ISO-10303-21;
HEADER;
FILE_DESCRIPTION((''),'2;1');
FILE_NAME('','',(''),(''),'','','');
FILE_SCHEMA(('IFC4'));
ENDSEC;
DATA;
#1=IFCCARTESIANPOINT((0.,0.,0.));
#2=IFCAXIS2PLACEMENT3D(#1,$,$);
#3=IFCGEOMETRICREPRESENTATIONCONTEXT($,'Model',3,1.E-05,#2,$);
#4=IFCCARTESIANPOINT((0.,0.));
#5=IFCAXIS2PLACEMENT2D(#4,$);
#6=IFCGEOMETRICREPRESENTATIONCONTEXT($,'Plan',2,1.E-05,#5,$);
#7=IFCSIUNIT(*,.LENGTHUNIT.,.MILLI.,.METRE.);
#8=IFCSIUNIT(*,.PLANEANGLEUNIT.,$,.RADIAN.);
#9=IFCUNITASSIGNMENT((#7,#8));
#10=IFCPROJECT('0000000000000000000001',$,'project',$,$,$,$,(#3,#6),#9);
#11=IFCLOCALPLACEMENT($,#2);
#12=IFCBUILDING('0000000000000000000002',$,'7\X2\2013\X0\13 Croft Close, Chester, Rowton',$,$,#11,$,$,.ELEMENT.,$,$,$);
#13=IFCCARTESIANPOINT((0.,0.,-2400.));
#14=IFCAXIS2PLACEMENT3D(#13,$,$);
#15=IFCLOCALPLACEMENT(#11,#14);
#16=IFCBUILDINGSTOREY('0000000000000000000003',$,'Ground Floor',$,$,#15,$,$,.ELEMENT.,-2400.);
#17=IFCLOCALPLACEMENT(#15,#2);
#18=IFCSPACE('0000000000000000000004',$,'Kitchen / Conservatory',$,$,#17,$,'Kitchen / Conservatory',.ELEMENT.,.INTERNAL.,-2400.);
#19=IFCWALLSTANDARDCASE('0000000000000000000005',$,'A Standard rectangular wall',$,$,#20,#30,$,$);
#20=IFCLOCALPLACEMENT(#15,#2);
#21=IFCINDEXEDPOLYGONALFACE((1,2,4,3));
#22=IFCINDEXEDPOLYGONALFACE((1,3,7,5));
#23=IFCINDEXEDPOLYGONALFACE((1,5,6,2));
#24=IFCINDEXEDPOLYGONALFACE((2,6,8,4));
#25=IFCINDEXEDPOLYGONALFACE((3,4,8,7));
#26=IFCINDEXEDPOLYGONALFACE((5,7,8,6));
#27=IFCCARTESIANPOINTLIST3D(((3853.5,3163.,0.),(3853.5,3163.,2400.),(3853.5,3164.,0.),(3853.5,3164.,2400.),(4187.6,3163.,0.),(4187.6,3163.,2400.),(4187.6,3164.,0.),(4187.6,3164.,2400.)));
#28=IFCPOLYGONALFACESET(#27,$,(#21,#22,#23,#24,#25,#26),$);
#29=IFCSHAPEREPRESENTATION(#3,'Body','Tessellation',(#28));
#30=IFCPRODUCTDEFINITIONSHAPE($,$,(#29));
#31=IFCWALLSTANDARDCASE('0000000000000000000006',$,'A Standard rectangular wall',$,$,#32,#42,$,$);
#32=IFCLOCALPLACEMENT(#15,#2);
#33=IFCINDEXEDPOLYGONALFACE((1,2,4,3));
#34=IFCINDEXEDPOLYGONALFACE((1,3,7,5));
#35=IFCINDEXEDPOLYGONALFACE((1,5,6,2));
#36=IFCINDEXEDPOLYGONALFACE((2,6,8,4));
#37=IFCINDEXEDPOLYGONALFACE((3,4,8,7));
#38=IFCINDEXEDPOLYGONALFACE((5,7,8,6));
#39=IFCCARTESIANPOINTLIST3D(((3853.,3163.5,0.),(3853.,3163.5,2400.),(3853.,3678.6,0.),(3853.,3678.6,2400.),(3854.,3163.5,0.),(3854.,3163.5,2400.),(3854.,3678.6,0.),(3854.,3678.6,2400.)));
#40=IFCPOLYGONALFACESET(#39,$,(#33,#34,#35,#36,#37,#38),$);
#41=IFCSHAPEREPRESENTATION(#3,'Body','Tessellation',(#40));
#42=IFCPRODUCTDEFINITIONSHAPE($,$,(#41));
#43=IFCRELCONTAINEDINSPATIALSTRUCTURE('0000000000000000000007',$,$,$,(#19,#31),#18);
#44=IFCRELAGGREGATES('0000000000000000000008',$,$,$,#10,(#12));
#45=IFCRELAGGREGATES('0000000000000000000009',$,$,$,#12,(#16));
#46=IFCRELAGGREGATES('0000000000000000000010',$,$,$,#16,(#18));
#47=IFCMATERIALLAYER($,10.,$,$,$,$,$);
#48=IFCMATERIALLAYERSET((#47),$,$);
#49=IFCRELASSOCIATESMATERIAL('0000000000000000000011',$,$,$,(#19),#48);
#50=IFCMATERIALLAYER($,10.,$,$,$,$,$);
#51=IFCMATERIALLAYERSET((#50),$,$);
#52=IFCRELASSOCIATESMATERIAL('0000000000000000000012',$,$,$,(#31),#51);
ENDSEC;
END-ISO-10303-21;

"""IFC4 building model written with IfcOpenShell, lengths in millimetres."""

from ifc_helpers import new_model, si_unit, frame, origin, origin_2d, place, context, project, spatial, rectangle, extrude, layer, layer_set, layer_usage, element, save


model = new_model("IFC4")

# Units and contexts
model_context = context("Model", 3, precision=1e-05, world=origin())
plan_context = context("Plan", 2, precision=1e-05, world=origin_2d())
ifc_project = project(units=[si_unit("LENGTHUNIT", "METRE", prefix="MILLI"), si_unit("PLANEANGLEUNIT", "RADIAN")], contexts=[model_context, plan_context])

# Building, storey, space
building_placement = place(None, origin())
building = spatial("IfcBuilding", under=ifc_project, at=building_placement, Name="7–13 Croft Close, Chester, Rowton", CompositionType="ELEMENT")
storey_placement = place(building_placement, frame((0.0, 0.0, -2400.0)))
storey = spatial("IfcBuildingStorey", under=building, at=storey_placement, Name="Ground Floor", CompositionType="ELEMENT", Elevation=-2400.0)
space_1_placement = place(storey_placement, origin())
space_1 = spatial("IfcSpace", under=storey, at=space_1_placement, Name="Kitchen / Conservatory", LongName="Kitchen / Conservatory", CompositionType="ELEMENT", PredefinedType="INTERNAL", ElevationWithFlooring=-2400.0)

# Walls
ifc_layer_1 = layer(None, 10.0)
ifc_layer_set_1 = layer_set([ifc_layer_1])
ifc_layer_usage_1 = layer_usage(ifc_layer_set_1, "AXIS2", "NEGATIVE", 150.0)
wall_1_placement = place(storey_placement, origin())
element("IfcWallStandardCase", 1, at=wall_1_placement, inside=space_1, material=ifc_layer_usage_1, Name="A Standard rectangular wall", context=model_context, shape_type="SweptSolid", body=[
    extrude(rectangle(XDim=1.0, YDim=334.1, at=origin_2d()), frame((4020.6, 3163.5, 0.0), x_axis=(0.0, -1.0, 0.0)), (0.0, 0.0, 1.0), 2400.0),
])
ifc_layer_2 = layer(None, 10.0)
ifc_layer_set_2 = layer_set([ifc_layer_2])
ifc_layer_usage_2 = layer_usage(ifc_layer_set_2, "AXIS2", "NEGATIVE", 150.0)
wall_2_placement = place(storey_placement, origin())
element("IfcWallStandardCase", 2, at=wall_2_placement, inside=space_1, material=ifc_layer_usage_2, Name="A Standard rectangular wall", context=model_context, shape_type="SweptSolid", body=[
    extrude(rectangle(XDim=1.0, YDim=515.1, at=origin_2d()), frame((3853.5, 3421.1, 0.0), x_axis=(-1.0, 0.0, 0.0)), (0.0, 0.0, 1.0), 2400.0),
])

save(model, "model.ifc")
